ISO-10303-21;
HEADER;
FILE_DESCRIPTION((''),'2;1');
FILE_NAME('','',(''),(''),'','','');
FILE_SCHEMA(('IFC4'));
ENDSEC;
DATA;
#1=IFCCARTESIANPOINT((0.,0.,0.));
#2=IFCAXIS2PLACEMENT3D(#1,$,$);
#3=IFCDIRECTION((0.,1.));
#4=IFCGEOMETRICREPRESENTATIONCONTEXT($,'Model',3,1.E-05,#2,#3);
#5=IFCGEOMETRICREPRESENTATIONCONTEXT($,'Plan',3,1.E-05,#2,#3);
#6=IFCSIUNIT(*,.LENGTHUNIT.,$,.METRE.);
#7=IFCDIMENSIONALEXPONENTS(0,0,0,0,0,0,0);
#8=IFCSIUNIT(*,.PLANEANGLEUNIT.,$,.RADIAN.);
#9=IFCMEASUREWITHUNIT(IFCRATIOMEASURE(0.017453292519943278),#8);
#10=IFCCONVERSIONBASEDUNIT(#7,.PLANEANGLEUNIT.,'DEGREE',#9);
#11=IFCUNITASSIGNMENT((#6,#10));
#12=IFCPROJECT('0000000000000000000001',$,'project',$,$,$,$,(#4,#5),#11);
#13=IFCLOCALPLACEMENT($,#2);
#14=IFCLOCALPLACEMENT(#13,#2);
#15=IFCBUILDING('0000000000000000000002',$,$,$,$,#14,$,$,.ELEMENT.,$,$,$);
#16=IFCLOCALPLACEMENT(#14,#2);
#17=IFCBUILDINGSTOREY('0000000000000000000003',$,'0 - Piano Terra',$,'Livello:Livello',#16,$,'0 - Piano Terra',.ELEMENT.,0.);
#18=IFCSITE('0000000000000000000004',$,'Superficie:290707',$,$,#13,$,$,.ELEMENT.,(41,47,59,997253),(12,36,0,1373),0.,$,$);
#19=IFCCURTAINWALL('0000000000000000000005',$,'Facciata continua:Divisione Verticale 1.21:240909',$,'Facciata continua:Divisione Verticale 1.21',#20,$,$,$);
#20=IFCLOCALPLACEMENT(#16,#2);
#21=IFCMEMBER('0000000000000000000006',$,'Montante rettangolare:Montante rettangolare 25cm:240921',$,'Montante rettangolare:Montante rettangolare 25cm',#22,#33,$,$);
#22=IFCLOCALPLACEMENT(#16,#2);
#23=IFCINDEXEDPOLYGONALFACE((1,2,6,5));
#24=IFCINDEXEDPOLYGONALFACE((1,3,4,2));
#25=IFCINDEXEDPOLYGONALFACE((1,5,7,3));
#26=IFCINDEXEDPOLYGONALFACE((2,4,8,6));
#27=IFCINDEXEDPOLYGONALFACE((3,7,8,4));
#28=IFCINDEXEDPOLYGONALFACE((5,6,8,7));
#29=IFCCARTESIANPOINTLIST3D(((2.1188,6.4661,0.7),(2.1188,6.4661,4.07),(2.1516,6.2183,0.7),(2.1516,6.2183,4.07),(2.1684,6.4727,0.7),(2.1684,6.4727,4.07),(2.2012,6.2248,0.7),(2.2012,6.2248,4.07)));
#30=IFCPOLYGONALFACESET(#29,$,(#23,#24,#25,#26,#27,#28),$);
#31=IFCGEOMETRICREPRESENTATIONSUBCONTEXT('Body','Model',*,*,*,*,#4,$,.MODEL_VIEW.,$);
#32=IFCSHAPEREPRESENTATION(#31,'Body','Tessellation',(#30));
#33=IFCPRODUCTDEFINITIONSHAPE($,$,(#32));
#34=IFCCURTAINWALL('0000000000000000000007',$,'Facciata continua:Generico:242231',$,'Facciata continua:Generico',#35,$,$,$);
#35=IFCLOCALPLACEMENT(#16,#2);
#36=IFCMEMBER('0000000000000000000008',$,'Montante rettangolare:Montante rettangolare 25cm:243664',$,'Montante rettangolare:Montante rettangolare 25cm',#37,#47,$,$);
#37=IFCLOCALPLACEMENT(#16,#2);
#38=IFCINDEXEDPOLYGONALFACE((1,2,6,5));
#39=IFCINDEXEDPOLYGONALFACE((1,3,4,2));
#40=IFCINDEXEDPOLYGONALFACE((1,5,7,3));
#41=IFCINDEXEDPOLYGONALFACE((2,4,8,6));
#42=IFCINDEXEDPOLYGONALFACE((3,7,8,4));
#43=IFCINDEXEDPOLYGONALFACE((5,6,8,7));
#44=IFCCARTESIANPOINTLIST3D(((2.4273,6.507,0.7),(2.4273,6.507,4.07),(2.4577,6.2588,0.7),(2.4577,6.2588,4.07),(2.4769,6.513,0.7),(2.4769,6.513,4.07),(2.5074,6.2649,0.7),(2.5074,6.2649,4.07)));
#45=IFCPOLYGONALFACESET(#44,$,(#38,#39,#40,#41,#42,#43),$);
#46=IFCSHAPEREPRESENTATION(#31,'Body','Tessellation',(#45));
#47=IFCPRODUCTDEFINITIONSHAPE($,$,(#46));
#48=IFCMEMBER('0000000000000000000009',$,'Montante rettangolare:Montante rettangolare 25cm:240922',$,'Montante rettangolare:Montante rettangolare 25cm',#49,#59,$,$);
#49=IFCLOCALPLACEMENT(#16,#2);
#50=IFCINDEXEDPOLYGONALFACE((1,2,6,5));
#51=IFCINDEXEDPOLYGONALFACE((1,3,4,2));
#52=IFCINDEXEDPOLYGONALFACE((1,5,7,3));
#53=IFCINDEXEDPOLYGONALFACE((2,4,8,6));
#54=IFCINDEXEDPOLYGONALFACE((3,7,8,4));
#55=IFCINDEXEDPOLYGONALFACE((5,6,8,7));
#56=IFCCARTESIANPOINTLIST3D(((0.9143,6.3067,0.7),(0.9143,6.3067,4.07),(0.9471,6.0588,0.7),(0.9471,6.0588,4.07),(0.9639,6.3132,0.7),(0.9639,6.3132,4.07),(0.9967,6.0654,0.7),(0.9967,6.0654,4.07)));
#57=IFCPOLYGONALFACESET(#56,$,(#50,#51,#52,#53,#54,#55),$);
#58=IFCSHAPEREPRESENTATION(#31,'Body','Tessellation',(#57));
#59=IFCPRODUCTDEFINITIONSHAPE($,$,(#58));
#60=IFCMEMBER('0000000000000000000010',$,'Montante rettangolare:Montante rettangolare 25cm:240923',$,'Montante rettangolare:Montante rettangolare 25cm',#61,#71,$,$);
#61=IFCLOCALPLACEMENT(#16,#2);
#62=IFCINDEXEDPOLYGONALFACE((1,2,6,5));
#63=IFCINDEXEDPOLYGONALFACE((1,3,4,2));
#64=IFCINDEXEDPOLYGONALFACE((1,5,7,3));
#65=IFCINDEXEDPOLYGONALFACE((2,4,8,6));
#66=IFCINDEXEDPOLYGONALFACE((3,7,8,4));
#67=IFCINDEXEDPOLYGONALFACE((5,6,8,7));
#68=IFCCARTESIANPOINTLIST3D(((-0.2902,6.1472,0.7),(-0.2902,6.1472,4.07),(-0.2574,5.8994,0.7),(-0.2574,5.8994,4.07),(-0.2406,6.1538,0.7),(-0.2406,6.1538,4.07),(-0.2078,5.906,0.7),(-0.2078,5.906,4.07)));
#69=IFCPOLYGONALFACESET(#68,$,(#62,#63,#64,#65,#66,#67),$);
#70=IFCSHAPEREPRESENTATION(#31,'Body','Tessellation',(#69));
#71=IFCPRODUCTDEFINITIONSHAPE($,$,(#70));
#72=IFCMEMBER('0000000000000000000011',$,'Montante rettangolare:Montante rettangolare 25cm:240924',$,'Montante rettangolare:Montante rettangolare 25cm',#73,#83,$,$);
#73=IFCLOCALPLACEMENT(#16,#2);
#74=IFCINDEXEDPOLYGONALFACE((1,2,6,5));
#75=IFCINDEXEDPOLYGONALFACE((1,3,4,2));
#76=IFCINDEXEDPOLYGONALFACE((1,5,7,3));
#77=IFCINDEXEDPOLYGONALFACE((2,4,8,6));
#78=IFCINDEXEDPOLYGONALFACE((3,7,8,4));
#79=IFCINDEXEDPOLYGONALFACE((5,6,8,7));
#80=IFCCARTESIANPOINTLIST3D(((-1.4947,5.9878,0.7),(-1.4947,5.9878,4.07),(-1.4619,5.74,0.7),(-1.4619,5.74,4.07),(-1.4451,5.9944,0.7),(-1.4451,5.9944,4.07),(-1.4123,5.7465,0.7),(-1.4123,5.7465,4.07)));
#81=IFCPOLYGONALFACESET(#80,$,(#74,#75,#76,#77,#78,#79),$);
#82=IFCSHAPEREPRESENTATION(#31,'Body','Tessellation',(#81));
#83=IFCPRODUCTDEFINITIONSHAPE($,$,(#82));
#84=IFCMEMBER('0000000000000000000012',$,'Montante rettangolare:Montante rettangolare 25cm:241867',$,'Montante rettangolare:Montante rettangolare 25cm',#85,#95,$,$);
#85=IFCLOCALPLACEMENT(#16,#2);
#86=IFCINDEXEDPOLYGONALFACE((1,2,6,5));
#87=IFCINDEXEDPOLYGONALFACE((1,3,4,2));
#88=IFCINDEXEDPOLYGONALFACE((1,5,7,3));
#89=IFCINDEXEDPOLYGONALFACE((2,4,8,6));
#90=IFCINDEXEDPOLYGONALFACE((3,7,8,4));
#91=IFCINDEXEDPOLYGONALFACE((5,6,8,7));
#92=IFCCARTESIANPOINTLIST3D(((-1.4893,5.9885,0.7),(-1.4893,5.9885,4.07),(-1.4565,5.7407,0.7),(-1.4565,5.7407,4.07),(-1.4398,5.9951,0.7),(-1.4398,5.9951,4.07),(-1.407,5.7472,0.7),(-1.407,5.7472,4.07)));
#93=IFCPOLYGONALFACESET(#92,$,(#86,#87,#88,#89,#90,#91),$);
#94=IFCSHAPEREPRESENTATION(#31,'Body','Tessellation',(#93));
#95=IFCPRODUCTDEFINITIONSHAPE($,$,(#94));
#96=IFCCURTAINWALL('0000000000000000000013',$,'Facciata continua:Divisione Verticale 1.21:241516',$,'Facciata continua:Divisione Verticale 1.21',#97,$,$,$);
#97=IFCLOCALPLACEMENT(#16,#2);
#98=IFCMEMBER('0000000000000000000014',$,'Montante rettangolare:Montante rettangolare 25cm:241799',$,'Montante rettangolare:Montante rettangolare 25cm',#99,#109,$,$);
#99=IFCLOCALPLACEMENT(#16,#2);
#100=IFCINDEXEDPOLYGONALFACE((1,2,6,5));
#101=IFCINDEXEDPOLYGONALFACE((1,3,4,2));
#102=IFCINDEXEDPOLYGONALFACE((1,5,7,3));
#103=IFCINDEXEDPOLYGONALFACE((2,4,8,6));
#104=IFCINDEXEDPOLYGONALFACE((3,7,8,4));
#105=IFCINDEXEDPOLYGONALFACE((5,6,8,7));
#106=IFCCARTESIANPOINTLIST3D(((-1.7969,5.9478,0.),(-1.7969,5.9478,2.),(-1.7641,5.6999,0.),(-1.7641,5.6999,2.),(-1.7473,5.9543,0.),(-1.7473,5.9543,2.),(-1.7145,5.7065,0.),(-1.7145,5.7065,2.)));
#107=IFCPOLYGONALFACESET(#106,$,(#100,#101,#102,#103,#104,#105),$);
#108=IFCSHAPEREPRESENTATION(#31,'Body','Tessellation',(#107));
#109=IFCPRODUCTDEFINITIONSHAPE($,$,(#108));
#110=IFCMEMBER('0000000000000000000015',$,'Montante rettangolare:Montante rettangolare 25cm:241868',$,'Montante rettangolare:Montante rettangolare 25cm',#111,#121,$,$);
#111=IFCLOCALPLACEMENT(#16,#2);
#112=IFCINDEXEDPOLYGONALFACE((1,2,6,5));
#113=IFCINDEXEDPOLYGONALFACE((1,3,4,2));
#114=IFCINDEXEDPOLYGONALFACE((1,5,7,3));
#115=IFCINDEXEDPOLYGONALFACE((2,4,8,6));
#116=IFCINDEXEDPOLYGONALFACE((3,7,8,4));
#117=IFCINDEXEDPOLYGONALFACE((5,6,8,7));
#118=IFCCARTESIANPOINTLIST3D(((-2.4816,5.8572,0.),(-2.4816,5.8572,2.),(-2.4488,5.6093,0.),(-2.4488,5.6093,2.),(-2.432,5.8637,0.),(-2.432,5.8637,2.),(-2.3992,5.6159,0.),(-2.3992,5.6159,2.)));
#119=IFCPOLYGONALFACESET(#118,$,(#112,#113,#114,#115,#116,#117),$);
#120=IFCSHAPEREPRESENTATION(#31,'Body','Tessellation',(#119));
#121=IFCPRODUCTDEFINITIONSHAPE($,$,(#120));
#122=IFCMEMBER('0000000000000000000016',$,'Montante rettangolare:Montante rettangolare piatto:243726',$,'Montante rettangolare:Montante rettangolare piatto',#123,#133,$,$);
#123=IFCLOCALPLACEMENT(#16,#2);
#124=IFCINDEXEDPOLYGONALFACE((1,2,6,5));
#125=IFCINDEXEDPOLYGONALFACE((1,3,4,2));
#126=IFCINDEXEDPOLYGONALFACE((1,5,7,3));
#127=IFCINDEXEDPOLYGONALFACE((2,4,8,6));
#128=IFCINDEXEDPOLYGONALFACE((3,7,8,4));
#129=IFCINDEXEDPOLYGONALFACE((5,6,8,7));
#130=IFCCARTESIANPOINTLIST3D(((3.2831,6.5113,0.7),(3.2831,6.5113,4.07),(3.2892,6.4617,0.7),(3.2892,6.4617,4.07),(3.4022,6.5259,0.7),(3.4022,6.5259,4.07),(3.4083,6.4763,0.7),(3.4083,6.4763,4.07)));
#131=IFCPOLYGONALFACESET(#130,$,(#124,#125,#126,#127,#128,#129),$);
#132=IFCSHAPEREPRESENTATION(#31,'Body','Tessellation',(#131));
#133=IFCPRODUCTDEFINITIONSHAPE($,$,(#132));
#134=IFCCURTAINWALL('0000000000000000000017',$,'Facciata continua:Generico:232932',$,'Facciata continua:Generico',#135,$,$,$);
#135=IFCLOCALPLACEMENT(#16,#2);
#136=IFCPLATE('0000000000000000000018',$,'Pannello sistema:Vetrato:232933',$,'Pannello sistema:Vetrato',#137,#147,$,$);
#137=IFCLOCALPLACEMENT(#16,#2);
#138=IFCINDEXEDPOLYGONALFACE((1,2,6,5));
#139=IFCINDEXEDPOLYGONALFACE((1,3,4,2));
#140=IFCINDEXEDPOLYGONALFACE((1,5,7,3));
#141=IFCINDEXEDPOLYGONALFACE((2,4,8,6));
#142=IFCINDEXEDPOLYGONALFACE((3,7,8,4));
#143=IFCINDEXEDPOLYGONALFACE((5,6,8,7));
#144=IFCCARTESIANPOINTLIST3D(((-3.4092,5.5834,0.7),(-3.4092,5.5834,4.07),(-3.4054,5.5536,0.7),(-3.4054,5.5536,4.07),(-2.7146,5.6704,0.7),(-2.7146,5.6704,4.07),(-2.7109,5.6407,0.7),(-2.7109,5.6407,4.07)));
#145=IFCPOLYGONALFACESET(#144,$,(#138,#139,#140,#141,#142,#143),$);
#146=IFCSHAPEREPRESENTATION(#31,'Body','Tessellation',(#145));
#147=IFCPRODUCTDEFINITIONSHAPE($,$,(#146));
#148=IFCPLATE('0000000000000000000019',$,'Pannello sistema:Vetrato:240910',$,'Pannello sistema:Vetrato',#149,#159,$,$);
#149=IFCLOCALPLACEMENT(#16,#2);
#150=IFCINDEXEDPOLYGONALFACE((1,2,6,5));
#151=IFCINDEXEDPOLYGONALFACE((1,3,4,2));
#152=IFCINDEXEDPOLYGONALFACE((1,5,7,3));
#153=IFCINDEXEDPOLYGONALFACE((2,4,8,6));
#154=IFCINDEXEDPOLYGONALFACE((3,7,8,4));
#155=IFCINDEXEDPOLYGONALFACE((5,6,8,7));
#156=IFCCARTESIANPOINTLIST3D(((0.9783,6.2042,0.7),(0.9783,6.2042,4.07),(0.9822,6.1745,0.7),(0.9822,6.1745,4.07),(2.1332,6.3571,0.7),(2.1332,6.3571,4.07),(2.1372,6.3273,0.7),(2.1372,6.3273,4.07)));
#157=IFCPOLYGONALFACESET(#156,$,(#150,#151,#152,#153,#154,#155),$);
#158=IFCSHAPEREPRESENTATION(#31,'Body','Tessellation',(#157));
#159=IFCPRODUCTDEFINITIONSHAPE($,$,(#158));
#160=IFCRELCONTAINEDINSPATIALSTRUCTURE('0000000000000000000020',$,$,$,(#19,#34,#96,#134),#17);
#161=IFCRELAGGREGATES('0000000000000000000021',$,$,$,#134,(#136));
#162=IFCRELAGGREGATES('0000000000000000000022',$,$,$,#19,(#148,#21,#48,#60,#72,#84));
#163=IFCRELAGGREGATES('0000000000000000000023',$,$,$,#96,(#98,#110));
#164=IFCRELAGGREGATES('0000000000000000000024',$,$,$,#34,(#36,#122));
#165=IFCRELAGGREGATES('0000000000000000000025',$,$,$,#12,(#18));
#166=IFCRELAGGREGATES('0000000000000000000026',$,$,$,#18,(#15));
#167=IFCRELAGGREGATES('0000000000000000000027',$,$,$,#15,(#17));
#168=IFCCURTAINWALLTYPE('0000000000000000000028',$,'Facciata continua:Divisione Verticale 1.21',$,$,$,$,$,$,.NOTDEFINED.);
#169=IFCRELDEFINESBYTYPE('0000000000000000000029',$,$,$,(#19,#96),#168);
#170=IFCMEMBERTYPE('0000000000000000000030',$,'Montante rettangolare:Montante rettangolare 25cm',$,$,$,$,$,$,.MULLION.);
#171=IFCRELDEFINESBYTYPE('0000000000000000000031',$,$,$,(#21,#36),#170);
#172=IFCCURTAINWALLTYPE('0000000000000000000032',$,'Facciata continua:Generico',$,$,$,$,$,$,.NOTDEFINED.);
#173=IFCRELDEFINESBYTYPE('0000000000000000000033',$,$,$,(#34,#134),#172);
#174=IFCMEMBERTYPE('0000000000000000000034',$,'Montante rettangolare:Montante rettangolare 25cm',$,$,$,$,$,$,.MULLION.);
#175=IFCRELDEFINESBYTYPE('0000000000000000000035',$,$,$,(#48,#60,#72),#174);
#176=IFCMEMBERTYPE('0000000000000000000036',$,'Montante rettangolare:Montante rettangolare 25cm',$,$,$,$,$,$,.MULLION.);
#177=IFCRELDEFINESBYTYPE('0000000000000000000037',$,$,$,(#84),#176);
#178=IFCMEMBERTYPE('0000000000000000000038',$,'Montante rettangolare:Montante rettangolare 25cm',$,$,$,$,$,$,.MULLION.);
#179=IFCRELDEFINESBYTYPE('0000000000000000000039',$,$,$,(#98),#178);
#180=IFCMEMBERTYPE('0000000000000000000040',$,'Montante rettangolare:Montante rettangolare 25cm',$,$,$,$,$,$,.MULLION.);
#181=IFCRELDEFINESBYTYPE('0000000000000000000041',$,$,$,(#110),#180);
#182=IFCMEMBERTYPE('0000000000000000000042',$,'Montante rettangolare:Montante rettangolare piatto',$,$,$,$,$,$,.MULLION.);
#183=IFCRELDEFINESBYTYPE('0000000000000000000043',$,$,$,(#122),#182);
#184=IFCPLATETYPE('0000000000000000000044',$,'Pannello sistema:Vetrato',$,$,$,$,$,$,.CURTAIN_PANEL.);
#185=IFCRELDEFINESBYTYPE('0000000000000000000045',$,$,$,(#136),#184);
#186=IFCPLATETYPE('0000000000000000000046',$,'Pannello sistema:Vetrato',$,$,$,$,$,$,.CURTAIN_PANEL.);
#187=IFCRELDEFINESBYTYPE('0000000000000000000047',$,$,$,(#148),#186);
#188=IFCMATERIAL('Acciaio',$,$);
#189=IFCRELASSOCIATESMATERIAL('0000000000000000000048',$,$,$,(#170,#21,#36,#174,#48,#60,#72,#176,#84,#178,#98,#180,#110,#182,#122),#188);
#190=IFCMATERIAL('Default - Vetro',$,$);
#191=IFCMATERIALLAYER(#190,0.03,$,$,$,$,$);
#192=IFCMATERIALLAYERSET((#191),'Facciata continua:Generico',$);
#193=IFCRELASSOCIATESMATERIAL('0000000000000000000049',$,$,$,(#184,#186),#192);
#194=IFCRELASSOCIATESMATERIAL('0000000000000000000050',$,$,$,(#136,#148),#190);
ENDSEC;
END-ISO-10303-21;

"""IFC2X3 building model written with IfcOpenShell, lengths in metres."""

from ifc_helpers import new_model, entity, si_unit, converted_unit, direction, frame, frame_2d, origin, origin_2d_with_axis, place, context, subcontext, project, spatial, rectangle, extrude, source, transform, mapped, material, layer, layer_set, type_object, type_shapes, element, aggregate, save


model = new_model("IFC2X3")

# Units and contexts
model_context = context("Model", 3, precision=1e-05, world=origin(), true_north=direction((0.0, 1.0)))
plan_context = context("Plan", 3, precision=1e-05, world=origin(), true_north=direction((0.0, 1.0)))
body_context = subcontext(model_context, "Body", "Model", "MODEL_VIEW")
ifc_project = project(units=[si_unit("LENGTHUNIT", "METRE"), converted_unit("PLANEANGLEUNIT", "DEGREE", entity("IfcRatioMeasure", 0.017453292519943278), si_unit("PLANEANGLEUNIT", "RADIAN"), dimensions=[0, 0, 0, 0, 0, 0, 0])], contexts=[model_context, plan_context])

# Site, building, storey
site_placement = place(None, origin())
site = spatial("IfcSite", under=ifc_project, at=site_placement, Name="Superficie:290707", CompositionType="ELEMENT", RefLatitude=(41, 47, 59, 997253), RefLongitude=(12, 36, 0, 1373), RefElevation=0.0)
building_placement = place(site_placement, origin())
building = spatial("IfcBuilding", under=site, at=building_placement, CompositionType="ELEMENT")
storey_placement = place(building_placement, origin())
storey = spatial("IfcBuildingStorey", under=building, at=storey_placement, Name="0 - Piano Terra", ObjectType="Livello:Livello", LongName="0 - Piano Terra", CompositionType="ELEMENT", Elevation=0.0)

# Curtain walls, members
curtain_wall_type_1 = type_object("IfcCurtainWallType", Name="Facciata continua:Divisione Verticale 1.21", PredefinedType="NOTDEFINED")
curtain_wall_1_placement = place(storey_placement, origin())
curtain_wall_1 = element("IfcCurtainWall", 1, at=curtain_wall_1_placement, inside=storey, type_object=curtain_wall_type_1, Name="Facciata continua:Divisione Verticale 1.21:240909", ObjectType="Facciata continua:Divisione Verticale 1.21")
ifc_material_1 = material(Name="Acciaio")
member_type_1 = type_object("IfcMemberType", Name="Montante rettangolare:Montante rettangolare 25cm", PredefinedType="MULLION", material=ifc_material_1)
shared_shape_1 = source(origin(), body_context, "Body", "SweptSolid", [
    extrude(rectangle(XDim=0.25, YDim=0.05, at=origin_2d_with_axis()), frame((-0.025, 0.0, -3.37), z_axis=(0.0, 0.0, 1.0), x_axis=(0.0, -1.0, 0.0)), (0.0, 0.0, 1.0), 3.37),
])
type_shapes(member_type_1, [shared_shape_1])
member_1_placement = place(curtain_wall_1_placement, frame((2.1848, 6.3488, 4.07), z_axis=(0.0, 0.0, 1.0), x_axis=(0.991352, 0.13123, 0.0)))
member_1 = element("IfcMember", 2, at=member_1_placement, type_object=member_type_1, material=ifc_material_1, Name="Montante rettangolare:Montante rettangolare 25cm:240921", ObjectType="Montante rettangolare:Montante rettangolare 25cm", context=body_context, shape_type="MappedRepresentation", body=[
    mapped(shared_shape_1, transform((0.0, 0.0, 0.0), scale=1.0)),
])
curtain_wall_type_2 = type_object("IfcCurtainWallType", Name="Facciata continua:Generico", PredefinedType="NOTDEFINED")
curtain_wall_2_placement = place(storey_placement, origin())
curtain_wall_2 = element("IfcCurtainWall", 3, at=curtain_wall_2_placement, inside=storey, type_object=curtain_wall_type_2, Name="Facciata continua:Generico:242231", ObjectType="Facciata continua:Generico")
member_2_placement = place(curtain_wall_2_placement, frame((2.4425, 6.3829, 4.07), z_axis=(0.0, 0.0, 1.0), x_axis=(-0.992546, -0.121869, 0.0)))
member_2 = element("IfcMember", 4, at=member_2_placement, type_object=member_type_1, material=ifc_material_1, Name="Montante rettangolare:Montante rettangolare 25cm:243664", ObjectType="Montante rettangolare:Montante rettangolare 25cm", context=body_context, shape_type="MappedRepresentation", body=[
    mapped(shared_shape_1, transform((0.0, 0.0, 0.0), scale=1.0)),
])

# Members
member_type_2 = type_object("IfcMemberType", Name="Montante rettangolare:Montante rettangolare 25cm", PredefinedType="MULLION", material=ifc_material_1)
shared_shape_2 = source(origin(), body_context, "Body", "SweptSolid", [
    extrude(rectangle(XDim=0.25, YDim=0.05, at=origin_2d_with_axis()), frame((0.0, 0.0, -3.37), z_axis=(0.0, 0.0, 1.0), x_axis=(0.0, -1.0, 0.0)), (0.0, 0.0, 1.0), 3.37),
])
type_shapes(member_type_2, [shared_shape_2])
member_3_placement = place(curtain_wall_1_placement, frame((0.9555, 6.186, 0.7), z_axis=(0.0, 0.0, -1.0), x_axis=(-0.991352, -0.13123, 0.0)))
member_3 = element("IfcMember", 5, at=member_3_placement, type_object=member_type_2, material=ifc_material_1, Name="Montante rettangolare:Montante rettangolare 25cm:240922", ObjectType="Montante rettangolare:Montante rettangolare 25cm", context=body_context, shape_type="MappedRepresentation", body=[
    mapped(shared_shape_2, transform((0.0, 0.0, 0.0), scale=1.0)),
])
member_4_placement = place(curtain_wall_1_placement, frame((-0.249, 6.0266, 0.7), z_axis=(0.0, 0.0, -1.0), x_axis=(-0.991352, -0.13123, 0.0)))
member_4 = element("IfcMember", 6, at=member_4_placement, type_object=member_type_2, material=ifc_material_1, Name="Montante rettangolare:Montante rettangolare 25cm:240923", ObjectType="Montante rettangolare:Montante rettangolare 25cm", context=body_context, shape_type="MappedRepresentation", body=[
    mapped(shared_shape_2, transform((0.0, 0.0, 0.0), scale=1.0)),
])
member_5_placement = place(curtain_wall_1_placement, frame((-1.4535, 5.8672, 0.7), z_axis=(0.0, 0.0, -1.0), x_axis=(-0.991352, -0.13123, 0.0)))
member_5 = element("IfcMember", 7, at=member_5_placement, type_object=member_type_2, material=ifc_material_1, Name="Montante rettangolare:Montante rettangolare 25cm:240924", ObjectType="Montante rettangolare:Montante rettangolare 25cm", context=body_context, shape_type="MappedRepresentation", body=[
    mapped(shared_shape_2, transform((0.0, 0.0, 0.0), scale=1.0)),
])
member_type_3 = type_object("IfcMemberType", Name="Montante rettangolare:Montante rettangolare 25cm", PredefinedType="MULLION", material=ifc_material_1)
shared_shape_3 = source(origin(), body_context, "Body", "SweptSolid", [
    extrude(rectangle(XDim=0.25, YDim=0.05, at=origin_2d_with_axis()), frame((-0.025, 0.0, -3.37), z_axis=(0.0, 0.0, 1.0), x_axis=(0.0, -1.0, 0.0)), (0.0, 0.0, 1.0), 3.37),
])
type_shapes(member_type_3, [shared_shape_3])
member_6_placement = place(curtain_wall_1_placement, frame((-1.4729, 5.8646, 0.7), z_axis=(0.0, 0.0, -1.0), x_axis=(-0.991352, -0.13123, 0.0)))
member_6 = element("IfcMember", 8, at=member_6_placement, type_object=member_type_3, material=ifc_material_1, Name="Montante rettangolare:Montante rettangolare 25cm:241867", ObjectType="Montante rettangolare:Montante rettangolare 25cm", context=body_context, shape_type="MappedRepresentation", body=[
    mapped(shared_shape_3, transform((0.0, 0.0, 0.0), scale=1.0)),
])

# Curtain wall, members
curtain_wall_3_placement = place(storey_placement, origin())
curtain_wall_3 = element("IfcCurtainWall", 9, at=curtain_wall_3_placement, inside=storey, type_object=curtain_wall_type_1, Name="Facciata continua:Divisione Verticale 1.21:241516", ObjectType="Facciata continua:Divisione Verticale 1.21")
member_type_4 = type_object("IfcMemberType", Name="Montante rettangolare:Montante rettangolare 25cm", PredefinedType="MULLION", material=ifc_material_1)
shared_shape_4 = source(origin(), body_context, "Body", "SweptSolid", [
    extrude(rectangle(XDim=0.25, YDim=0.05, at=origin_2d_with_axis()), frame((-0.025, 0.0, -2.0), z_axis=(0.0, 0.0, 1.0), x_axis=(0.0, -1.0, 0.0)), (0.0, 0.0, 1.0), 2.0),
])
type_shapes(member_type_4, [shared_shape_4])
member_7_placement = place(curtain_wall_3_placement, frame((-1.7309, 5.8304, 2.0), z_axis=(0.0, 0.0, 1.0), x_axis=(0.991352, 0.13123, 0.0)))
member_7 = element("IfcMember", 10, at=member_7_placement, type_object=member_type_4, material=ifc_material_1, Name="Montante rettangolare:Montante rettangolare 25cm:241799", ObjectType="Montante rettangolare:Montante rettangolare 25cm", context=body_context, shape_type="MappedRepresentation", body=[
    mapped(shared_shape_4, transform((0.0, 0.0, 0.0), scale=1.0)),
])
member_type_5 = type_object("IfcMemberType", Name="Montante rettangolare:Montante rettangolare 25cm", PredefinedType="MULLION", material=ifc_material_1)
shared_shape_5 = source(origin(), body_context, "Body", "SweptSolid", [
    extrude(rectangle(XDim=0.25, YDim=0.05, at=origin_2d_with_axis()), frame((-0.025, 0.0, -2.0), z_axis=(0.0, 0.0, 1.0), x_axis=(0.0, -1.0, 0.0)), (0.0, 0.0, 1.0), 2.0),
])
type_shapes(member_type_5, [shared_shape_5])
member_8_placement = place(curtain_wall_3_placement, frame((-2.4652, 5.7332, 0.0), z_axis=(0.0, 0.0, -1.0), x_axis=(-0.991352, -0.13123, 0.0)))
member_8 = element("IfcMember", 11, at=member_8_placement, type_object=member_type_5, material=ifc_material_1, Name="Montante rettangolare:Montante rettangolare 25cm:241868", ObjectType="Montante rettangolare:Montante rettangolare 25cm", context=body_context, shape_type="MappedRepresentation", body=[
    mapped(shared_shape_5, transform((0.0, 0.0, 0.0), scale=1.0)),
])

# Member
member_type_6 = type_object("IfcMemberType", Name="Montante rettangolare:Montante rettangolare piatto", PredefinedType="MULLION", material=ifc_material_1)
shared_shape_6 = source(origin(), body_context, "Body", "SweptSolid", [
    extrude(rectangle(XDim=0.05, YDim=0.12, at=origin_2d_with_axis()), frame((0.0, 0.0, -3.37), z_axis=(0.0, 0.0, 1.0), x_axis=(0.0, -1.0, 0.0)), (0.0, 0.0, 1.0), 3.37),
])
type_shapes(member_type_6, [shared_shape_6])
member_9_placement = place(curtain_wall_2_placement, frame((3.3457, 6.4938, 0.7), z_axis=(0.0, 0.0, -1.0), x_axis=(0.992546, 0.121869, 0.0)))
member_9 = element("IfcMember", 12, at=member_9_placement, type_object=member_type_6, material=ifc_material_1, Name="Montante rettangolare:Montante rettangolare piatto:243726", ObjectType="Montante rettangolare:Montante rettangolare piatto", context=body_context, shape_type="MappedRepresentation", body=[
    mapped(shared_shape_6, transform((0.0, 0.0, 0.0), scale=1.0)),
])

# Curtain wall, plate
curtain_wall_4_placement = place(storey_placement, origin())
curtain_wall_4 = element("IfcCurtainWall", 13, at=curtain_wall_4_placement, inside=storey, type_object=curtain_wall_type_2, Name="Facciata continua:Generico:232932", ObjectType="Facciata continua:Generico")
ifc_material_2 = material(Name="Default - Vetro")
ifc_layer_1 = layer(ifc_material_2, 0.03)
ifc_layer_set_1 = layer_set([ifc_layer_1], Name="Facciata continua:Generico")
plate_type_1 = type_object("IfcPlateType", Name="Pannello sistema:Vetrato", PredefinedType="CURTAIN_PANEL", material=ifc_layer_set_1)
shared_shape_7 = source(origin(), body_context, "Body", "SweptSolid", [
    extrude(rectangle(XDim=0.03, YDim=0.7, at=frame_2d((0.0, 0.0), x_axis=(1.0, 0.0))), frame((0.0, 0.0, 0.0), z_axis=(0.0, 0.0, 1.0), x_axis=(0.0, 1.0, 0.0)), (0.0, 0.0, 1.0), 3.37),
])
type_shapes(plate_type_1, [shared_shape_7])
plate_1_placement = place(curtain_wall_4_placement, frame((-3.06, 5.612, 0.7), z_axis=(0.0, 0.0, 1.0), x_axis=(0.992236, 0.124371, 0.0)))
plate_1 = element("IfcPlate", 14, at=plate_1_placement, type_object=plate_type_1, material=ifc_material_2, Name="Pannello sistema:Vetrato:232933", ObjectType="Pannello sistema:Vetrato", context=body_context, shape_type="MappedRepresentation", body=[
    mapped(shared_shape_7, transform((0.0, 0.0, 0.0), scale=1.0)),
])
aggregate(curtain_wall_4, [plate_1])

# Plate
plate_type_2 = type_object("IfcPlateType", Name="Pannello sistema:Vetrato", PredefinedType="CURTAIN_PANEL", material=ifc_layer_set_1)
shared_shape_8 = source(origin(), body_context, "Body", "SweptSolid", [
    extrude(rectangle(XDim=0.03, YDim=1.165, at=origin_2d_with_axis()), frame((0.0, 0.0, 0.0), z_axis=(0.0, 0.0, 1.0), x_axis=(0.0, 1.0, 0.0)), (0.0, 0.0, 1.0), 3.37),
])
type_shapes(plate_type_2, [shared_shape_8])
plate_2_placement = place(curtain_wall_1_placement, frame((1.5577, 6.2658, 0.7), z_axis=(0.0, 0.0, 1.0), x_axis=(-0.991352, -0.13123, 0.0)))
plate_2 = element("IfcPlate", 15, at=plate_2_placement, type_object=plate_type_2, material=ifc_material_2, Name="Pannello sistema:Vetrato:240910", ObjectType="Pannello sistema:Vetrato", context=body_context, shape_type="MappedRepresentation", body=[
    mapped(shared_shape_8, transform((0.0, 0.0, 0.0), scale=1.0)),
])
aggregate(curtain_wall_1, [plate_2, member_1, member_3, member_4, member_5, member_6])
aggregate(curtain_wall_3, [member_7, member_8])
aggregate(curtain_wall_2, [member_2, member_9])

save(model, "model.ifc")
